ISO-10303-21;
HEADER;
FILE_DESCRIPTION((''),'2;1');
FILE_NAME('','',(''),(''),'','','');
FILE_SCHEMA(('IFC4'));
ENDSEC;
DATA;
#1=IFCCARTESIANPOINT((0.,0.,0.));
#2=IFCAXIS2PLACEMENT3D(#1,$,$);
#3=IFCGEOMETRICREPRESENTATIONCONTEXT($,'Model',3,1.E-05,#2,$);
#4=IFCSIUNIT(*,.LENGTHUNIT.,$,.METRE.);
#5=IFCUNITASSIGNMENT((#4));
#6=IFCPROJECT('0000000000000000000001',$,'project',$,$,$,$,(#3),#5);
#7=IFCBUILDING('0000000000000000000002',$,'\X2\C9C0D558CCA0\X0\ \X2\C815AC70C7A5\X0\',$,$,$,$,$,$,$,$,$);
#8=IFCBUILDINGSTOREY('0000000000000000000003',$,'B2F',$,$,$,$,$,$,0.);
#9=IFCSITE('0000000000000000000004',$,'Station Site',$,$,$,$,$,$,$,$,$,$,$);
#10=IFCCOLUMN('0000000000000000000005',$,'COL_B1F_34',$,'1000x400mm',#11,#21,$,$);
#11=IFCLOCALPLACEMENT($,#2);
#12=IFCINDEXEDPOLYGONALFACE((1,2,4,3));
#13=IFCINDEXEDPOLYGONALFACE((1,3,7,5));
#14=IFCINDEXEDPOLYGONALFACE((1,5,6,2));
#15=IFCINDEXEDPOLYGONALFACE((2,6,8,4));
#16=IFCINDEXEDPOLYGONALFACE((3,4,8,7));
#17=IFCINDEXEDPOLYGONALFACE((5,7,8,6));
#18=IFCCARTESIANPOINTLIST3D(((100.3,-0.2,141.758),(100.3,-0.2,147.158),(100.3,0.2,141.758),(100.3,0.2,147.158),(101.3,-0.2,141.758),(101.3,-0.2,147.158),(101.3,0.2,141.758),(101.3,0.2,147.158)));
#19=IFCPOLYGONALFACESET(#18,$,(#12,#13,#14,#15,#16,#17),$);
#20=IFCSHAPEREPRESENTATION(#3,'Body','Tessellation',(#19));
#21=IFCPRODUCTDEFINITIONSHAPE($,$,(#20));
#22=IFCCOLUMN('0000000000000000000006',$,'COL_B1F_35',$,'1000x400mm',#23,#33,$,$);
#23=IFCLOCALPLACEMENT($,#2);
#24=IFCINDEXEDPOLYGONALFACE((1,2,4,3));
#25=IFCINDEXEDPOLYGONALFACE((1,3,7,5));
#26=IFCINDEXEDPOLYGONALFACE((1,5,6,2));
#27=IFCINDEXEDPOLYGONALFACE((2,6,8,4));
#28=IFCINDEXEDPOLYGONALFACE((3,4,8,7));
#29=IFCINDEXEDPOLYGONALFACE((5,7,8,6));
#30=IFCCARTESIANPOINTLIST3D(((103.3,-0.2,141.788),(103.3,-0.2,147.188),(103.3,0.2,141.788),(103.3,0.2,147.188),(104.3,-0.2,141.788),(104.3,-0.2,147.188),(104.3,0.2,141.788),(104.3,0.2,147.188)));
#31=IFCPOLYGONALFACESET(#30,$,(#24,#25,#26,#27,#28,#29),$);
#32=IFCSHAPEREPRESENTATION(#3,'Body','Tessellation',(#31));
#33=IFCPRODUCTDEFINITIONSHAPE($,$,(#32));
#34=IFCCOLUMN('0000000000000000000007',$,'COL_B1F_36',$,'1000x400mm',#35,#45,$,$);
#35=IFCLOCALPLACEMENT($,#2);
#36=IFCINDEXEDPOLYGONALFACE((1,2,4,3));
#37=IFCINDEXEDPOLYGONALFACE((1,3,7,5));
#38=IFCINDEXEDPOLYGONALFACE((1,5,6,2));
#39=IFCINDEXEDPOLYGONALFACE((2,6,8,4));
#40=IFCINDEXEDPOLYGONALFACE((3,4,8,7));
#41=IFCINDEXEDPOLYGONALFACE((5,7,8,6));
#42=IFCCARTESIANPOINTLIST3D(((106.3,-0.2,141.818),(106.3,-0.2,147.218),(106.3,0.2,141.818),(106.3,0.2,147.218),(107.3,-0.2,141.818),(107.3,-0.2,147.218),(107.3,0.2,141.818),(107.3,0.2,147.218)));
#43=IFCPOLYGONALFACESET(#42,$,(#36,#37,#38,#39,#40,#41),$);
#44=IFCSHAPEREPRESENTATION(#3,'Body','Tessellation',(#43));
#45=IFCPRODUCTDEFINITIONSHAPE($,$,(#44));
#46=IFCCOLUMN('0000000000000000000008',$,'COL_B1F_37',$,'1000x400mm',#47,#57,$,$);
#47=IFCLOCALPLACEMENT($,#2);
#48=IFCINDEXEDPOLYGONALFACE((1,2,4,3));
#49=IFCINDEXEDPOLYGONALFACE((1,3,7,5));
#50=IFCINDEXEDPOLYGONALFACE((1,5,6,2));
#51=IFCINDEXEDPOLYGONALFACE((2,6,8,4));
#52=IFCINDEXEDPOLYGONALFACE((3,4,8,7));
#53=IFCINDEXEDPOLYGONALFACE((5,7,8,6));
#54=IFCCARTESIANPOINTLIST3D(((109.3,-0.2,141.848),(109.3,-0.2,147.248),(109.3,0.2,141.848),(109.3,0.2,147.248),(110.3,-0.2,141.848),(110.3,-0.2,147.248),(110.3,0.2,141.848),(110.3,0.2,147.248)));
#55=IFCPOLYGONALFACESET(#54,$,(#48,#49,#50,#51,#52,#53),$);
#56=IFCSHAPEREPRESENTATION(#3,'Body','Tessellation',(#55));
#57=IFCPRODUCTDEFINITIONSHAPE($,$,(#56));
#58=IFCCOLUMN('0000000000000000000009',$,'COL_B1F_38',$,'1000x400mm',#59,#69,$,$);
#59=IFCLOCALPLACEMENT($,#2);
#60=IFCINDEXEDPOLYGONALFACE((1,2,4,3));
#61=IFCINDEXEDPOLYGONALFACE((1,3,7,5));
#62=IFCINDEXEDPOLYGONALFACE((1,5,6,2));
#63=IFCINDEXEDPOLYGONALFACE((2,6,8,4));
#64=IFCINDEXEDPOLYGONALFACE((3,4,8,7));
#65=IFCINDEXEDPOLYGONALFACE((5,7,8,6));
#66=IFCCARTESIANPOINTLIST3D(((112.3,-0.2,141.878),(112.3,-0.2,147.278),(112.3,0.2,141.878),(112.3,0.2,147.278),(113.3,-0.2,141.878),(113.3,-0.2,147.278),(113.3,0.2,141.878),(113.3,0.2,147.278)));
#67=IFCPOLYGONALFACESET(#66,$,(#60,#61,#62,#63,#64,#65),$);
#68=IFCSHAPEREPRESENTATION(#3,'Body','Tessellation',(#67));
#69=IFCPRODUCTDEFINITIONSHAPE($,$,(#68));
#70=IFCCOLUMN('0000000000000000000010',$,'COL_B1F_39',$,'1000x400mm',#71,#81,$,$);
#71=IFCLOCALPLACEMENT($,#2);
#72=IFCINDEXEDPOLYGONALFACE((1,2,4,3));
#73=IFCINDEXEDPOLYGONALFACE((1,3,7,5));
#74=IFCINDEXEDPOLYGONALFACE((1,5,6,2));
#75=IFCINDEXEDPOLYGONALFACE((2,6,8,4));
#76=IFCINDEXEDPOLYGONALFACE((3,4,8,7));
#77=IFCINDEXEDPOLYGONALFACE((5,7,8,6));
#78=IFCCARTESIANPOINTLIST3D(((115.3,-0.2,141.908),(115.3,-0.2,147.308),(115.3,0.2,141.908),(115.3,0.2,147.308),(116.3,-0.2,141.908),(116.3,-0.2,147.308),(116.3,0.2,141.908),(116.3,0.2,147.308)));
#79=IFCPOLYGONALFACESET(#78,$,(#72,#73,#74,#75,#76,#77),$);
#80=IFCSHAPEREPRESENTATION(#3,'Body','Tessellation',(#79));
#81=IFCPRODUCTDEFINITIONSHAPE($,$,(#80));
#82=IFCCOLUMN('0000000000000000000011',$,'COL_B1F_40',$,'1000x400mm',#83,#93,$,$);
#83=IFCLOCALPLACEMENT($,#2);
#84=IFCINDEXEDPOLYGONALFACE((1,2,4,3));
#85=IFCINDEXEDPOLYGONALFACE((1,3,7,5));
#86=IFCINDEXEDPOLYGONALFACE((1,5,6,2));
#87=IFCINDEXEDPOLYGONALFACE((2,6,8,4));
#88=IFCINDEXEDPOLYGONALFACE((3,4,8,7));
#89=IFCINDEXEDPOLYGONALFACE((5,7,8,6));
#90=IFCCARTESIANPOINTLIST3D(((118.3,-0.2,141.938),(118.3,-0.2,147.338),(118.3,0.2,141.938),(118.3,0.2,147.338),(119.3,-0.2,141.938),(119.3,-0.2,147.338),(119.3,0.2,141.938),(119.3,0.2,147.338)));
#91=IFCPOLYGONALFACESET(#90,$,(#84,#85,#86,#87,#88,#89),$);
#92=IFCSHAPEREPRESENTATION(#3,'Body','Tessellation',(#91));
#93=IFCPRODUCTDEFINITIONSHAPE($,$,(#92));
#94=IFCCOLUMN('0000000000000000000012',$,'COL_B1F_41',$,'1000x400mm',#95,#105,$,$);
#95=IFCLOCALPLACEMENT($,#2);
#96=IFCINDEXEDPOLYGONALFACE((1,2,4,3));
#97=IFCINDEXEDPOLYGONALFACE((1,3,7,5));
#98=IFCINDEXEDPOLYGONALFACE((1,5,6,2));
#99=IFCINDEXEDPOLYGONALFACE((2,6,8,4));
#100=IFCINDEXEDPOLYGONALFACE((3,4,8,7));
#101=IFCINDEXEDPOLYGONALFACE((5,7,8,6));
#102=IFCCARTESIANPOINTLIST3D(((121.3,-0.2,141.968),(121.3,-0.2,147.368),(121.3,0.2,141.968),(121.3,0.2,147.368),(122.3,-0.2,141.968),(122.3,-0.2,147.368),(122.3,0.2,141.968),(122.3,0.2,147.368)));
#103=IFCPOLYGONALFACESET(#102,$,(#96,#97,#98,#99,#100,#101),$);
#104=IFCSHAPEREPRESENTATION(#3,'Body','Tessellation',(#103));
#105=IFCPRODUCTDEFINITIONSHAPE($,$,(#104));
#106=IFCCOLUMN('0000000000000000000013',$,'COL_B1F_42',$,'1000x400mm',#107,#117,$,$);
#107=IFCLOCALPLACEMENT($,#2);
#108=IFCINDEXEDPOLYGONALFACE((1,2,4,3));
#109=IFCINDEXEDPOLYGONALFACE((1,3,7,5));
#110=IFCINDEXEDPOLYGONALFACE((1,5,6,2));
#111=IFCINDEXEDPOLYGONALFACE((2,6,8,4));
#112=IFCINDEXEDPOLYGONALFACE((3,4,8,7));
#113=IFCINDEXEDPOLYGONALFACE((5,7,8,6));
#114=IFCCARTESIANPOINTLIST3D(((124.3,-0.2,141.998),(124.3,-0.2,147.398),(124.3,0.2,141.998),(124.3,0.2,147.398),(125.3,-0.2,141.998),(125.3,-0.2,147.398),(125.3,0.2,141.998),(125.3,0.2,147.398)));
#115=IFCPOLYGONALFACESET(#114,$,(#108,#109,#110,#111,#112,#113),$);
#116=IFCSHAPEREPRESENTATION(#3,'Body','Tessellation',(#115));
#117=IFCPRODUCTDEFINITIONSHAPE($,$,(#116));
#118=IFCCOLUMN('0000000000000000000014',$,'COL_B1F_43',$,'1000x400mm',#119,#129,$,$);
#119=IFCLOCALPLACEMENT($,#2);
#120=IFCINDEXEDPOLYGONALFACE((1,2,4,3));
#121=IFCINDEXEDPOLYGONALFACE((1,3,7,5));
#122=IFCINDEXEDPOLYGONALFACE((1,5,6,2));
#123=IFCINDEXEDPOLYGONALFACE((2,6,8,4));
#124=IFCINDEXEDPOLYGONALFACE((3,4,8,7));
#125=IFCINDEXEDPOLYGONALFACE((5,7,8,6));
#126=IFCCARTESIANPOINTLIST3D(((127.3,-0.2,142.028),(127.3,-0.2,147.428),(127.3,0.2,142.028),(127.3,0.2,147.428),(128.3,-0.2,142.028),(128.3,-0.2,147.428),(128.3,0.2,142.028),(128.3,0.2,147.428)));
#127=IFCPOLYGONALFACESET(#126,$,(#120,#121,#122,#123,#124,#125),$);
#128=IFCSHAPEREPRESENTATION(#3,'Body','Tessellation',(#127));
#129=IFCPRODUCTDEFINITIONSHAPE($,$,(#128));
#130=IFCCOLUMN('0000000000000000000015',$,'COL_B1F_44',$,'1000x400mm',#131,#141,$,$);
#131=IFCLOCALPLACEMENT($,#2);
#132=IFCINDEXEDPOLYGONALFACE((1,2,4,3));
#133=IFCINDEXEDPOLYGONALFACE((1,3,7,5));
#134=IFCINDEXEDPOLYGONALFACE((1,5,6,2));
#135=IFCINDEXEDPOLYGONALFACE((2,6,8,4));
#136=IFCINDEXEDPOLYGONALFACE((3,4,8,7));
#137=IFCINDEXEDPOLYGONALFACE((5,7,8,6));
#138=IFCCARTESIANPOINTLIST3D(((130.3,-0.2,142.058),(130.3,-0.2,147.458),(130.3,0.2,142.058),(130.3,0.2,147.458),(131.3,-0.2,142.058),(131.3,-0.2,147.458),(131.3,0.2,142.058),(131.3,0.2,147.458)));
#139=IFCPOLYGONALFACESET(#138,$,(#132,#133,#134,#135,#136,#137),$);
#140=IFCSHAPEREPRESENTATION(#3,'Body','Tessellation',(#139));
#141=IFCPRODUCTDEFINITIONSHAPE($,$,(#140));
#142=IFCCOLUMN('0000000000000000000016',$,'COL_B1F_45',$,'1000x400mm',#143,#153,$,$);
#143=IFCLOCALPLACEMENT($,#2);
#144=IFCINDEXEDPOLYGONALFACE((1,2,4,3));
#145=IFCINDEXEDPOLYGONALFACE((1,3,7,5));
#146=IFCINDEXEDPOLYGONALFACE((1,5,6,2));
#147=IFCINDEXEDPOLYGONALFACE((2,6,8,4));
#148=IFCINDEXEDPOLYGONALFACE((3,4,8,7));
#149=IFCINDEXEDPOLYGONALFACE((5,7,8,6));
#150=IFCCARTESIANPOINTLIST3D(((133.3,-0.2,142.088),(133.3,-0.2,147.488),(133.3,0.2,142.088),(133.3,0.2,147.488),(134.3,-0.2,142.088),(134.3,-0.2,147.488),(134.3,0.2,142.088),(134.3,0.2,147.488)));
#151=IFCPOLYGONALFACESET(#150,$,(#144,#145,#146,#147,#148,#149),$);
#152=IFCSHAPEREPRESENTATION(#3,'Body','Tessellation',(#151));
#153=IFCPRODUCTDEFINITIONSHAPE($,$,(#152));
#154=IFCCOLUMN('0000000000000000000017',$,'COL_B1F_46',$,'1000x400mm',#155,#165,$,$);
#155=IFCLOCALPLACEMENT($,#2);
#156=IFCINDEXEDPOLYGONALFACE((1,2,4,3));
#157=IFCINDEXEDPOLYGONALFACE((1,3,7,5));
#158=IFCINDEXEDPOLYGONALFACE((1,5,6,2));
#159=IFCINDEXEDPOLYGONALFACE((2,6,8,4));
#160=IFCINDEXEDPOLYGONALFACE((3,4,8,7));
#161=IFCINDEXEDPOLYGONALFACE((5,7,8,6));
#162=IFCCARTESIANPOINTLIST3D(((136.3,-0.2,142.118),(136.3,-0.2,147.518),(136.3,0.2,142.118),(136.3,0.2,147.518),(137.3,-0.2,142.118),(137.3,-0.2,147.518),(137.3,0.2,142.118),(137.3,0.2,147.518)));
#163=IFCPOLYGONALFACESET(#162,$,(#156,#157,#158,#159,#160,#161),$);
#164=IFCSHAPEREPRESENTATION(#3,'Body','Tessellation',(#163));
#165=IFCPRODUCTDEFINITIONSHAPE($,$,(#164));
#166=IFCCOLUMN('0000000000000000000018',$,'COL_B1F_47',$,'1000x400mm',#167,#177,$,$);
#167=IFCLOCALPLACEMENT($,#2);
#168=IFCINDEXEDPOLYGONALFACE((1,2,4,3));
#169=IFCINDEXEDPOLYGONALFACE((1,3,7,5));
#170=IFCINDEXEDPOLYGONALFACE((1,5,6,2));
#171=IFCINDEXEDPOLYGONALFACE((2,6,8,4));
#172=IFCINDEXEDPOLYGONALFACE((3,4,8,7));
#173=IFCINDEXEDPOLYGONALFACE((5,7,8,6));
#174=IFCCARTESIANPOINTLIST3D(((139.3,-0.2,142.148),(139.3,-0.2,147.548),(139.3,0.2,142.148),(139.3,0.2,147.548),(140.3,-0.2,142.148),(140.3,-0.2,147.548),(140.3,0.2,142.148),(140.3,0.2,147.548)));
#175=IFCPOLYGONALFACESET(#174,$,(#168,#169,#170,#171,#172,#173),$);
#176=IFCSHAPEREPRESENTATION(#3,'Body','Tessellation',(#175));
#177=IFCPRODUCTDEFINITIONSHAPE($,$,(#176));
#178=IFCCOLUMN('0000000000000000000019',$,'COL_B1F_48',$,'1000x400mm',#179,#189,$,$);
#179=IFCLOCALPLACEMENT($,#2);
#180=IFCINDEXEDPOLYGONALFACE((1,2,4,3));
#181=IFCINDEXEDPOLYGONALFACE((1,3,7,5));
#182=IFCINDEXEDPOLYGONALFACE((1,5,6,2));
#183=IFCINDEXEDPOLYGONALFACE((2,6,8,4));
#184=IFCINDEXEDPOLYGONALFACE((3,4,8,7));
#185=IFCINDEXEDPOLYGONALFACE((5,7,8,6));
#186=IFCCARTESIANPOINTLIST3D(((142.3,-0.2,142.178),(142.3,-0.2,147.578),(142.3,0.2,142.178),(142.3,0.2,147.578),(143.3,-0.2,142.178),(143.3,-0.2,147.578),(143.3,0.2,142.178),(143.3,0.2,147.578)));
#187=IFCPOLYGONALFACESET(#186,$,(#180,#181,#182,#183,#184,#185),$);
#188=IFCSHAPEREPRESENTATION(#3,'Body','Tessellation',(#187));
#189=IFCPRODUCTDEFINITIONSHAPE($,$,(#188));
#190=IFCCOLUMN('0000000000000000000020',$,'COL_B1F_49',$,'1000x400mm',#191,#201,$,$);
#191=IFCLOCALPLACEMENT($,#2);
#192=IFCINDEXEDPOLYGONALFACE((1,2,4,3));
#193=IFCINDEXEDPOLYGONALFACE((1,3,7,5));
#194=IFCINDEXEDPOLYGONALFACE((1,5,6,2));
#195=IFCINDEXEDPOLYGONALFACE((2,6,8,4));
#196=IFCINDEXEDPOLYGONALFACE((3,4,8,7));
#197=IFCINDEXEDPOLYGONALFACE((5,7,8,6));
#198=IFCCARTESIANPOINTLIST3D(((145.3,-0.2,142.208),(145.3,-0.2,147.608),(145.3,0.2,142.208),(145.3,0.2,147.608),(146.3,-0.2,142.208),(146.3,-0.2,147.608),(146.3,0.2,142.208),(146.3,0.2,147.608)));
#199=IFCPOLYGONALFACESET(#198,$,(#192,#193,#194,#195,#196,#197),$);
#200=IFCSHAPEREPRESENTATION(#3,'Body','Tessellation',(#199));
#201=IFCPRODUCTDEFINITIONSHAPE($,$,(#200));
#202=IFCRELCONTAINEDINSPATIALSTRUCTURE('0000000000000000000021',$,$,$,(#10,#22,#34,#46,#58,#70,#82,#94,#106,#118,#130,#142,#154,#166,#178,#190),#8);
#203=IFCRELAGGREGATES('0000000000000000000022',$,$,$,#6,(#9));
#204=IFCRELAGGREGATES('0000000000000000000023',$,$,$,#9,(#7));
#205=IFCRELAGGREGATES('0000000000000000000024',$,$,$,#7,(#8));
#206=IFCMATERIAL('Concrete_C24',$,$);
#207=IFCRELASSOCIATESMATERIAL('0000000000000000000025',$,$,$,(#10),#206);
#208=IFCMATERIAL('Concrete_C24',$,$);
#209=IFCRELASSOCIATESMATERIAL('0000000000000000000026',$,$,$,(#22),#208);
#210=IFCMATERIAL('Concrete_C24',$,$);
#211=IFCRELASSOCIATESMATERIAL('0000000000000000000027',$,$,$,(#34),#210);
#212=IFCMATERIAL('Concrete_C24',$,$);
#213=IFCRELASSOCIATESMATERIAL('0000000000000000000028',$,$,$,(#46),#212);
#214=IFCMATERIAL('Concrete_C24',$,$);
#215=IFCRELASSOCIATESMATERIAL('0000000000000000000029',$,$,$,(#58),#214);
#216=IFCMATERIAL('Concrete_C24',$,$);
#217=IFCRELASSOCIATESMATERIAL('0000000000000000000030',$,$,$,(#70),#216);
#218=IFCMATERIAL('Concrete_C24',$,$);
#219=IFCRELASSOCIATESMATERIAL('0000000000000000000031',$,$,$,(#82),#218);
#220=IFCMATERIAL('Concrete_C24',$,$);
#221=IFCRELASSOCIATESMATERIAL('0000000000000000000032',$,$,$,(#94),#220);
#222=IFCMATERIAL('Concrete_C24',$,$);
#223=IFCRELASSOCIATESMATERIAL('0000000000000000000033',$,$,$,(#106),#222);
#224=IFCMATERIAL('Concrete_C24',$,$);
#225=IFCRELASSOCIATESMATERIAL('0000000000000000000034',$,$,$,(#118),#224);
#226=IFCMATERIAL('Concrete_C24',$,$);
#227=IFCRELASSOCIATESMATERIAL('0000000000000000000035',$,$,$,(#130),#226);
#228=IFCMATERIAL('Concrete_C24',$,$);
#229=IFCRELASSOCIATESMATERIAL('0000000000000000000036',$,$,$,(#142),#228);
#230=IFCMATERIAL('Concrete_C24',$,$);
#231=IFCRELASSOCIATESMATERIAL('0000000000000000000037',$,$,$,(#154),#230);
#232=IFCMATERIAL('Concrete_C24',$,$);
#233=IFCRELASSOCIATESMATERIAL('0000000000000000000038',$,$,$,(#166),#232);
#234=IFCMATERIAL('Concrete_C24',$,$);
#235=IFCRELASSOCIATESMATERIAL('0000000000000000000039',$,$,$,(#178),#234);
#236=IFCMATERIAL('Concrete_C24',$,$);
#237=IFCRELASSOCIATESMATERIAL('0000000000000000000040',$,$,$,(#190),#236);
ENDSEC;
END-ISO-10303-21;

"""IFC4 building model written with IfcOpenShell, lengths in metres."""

from ifc_helpers import new_model, si_unit, frame, origin, place, context, project, spatial, rectangle, extrude, material, element, save


model = new_model("IFC4")

# Units and contexts
model_context = context("Model", 3, precision=1e-05, world=origin())
ifc_project = project(units=[si_unit("LENGTHUNIT", "METRE")], contexts=[model_context])

# Site, building, storey
site = spatial("IfcSite", under=ifc_project, Name="Station Site")
building = spatial("IfcBuilding", under=site, Name="지하철 정거장")
storey = spatial("IfcBuildingStorey", under=building, Name="B2F", Elevation=0.0)

# Columns
ifc_material_1 = material(Name="Concrete_C24")
column_1_placement = place(None, frame((100.8, 0.0, 141.758)))
element("IfcColumn", 1, at=column_1_placement, inside=storey, material=ifc_material_1, Name="COL_B1F_34", ObjectType="1000x400mm", context=model_context, shape_type="SweptSolid", body=[
    extrude(rectangle(XDim=1.0, YDim=0.4), origin(), (0.0, 0.0, 1.0), 5.4),
])
ifc_material_2 = material(Name="Concrete_C24")
column_2_placement = place(None, frame((103.8, 0.0, 141.788)))
element("IfcColumn", 2, at=column_2_placement, inside=storey, material=ifc_material_2, Name="COL_B1F_35", ObjectType="1000x400mm", context=model_context, shape_type="SweptSolid", body=[
    extrude(rectangle(XDim=1.0, YDim=0.4), origin(), (0.0, 0.0, 1.0), 5.4),
])
ifc_material_3 = material(Name="Concrete_C24")
column_3_placement = place(None, frame((106.8, 0.0, 141.818)))
element("IfcColumn", 3, at=column_3_placement, inside=storey, material=ifc_material_3, Name="COL_B1F_36", ObjectType="1000x400mm", context=model_context, shape_type="SweptSolid", body=[
    extrude(rectangle(XDim=1.0, YDim=0.4), origin(), (0.0, 0.0, 1.0), 5.4),
])
ifc_material_4 = material(Name="Concrete_C24")
column_4_placement = place(None, frame((109.8, 0.0, 141.848)))
element("IfcColumn", 4, at=column_4_placement, inside=storey, material=ifc_material_4, Name="COL_B1F_37", ObjectType="1000x400mm", context=model_context, shape_type="SweptSolid", body=[
    extrude(rectangle(XDim=1.0, YDim=0.4), origin(), (0.0, 0.0, 1.0), 5.4),
])
ifc_material_5 = material(Name="Concrete_C24")
column_5_placement = place(None, frame((112.8, 0.0, 141.878)))
element("IfcColumn", 5, at=column_5_placement, inside=storey, material=ifc_material_5, Name="COL_B1F_38", ObjectType="1000x400mm", context=model_context, shape_type="SweptSolid", body=[
    extrude(rectangle(XDim=1.0, YDim=0.4), origin(), (0.0, 0.0, 1.0), 5.4),
])
ifc_material_6 = material(Name="Concrete_C24")
column_6_placement = place(None, frame((115.8, 0.0, 141.908)))
element("IfcColumn", 6, at=column_6_placement, inside=storey, material=ifc_material_6, Name="COL_B1F_39", ObjectType="1000x400mm", context=model_context, shape_type="SweptSolid", body=[
    extrude(rectangle(XDim=1.0, YDim=0.4), origin(), (0.0, 0.0, 1.0), 5.4),
])
ifc_material_7 = material(Name="Concrete_C24")
column_7_placement = place(None, frame((118.8, 0.0, 141.938)))
element("IfcColumn", 7, at=column_7_placement, inside=storey, material=ifc_material_7, Name="COL_B1F_40", ObjectType="1000x400mm", context=model_context, shape_type="SweptSolid", body=[
    extrude(rectangle(XDim=1.0, YDim=0.4), origin(), (0.0, 0.0, 1.0), 5.4),
])
ifc_material_8 = material(Name="Concrete_C24")
column_8_placement = place(None, frame((121.8, 0.0, 141.968)))
element("IfcColumn", 8, at=column_8_placement, inside=storey, material=ifc_material_8, Name="COL_B1F_41", ObjectType="1000x400mm", context=model_context, shape_type="SweptSolid", body=[
    extrude(rectangle(XDim=1.0, YDim=0.4), origin(), (0.0, 0.0, 1.0), 5.4),
])
ifc_material_9 = material(Name="Concrete_C24")
column_9_placement = place(None, frame((124.8, 0.0, 141.998)))
element("IfcColumn", 9, at=column_9_placement, inside=storey, material=ifc_material_9, Name="COL_B1F_42", ObjectType="1000x400mm", context=model_context, shape_type="SweptSolid", body=[
    extrude(rectangle(XDim=1.0, YDim=0.4), origin(), (0.0, 0.0, 1.0), 5.4),
])
ifc_material_10 = material(Name="Concrete_C24")
column_10_placement = place(None, frame((127.8, 0.0, 142.028)))
element("IfcColumn", 10, at=column_10_placement, inside=storey, material=ifc_material_10, Name="COL_B1F_43", ObjectType="1000x400mm", context=model_context, shape_type="SweptSolid", body=[
    extrude(rectangle(XDim=1.0, YDim=0.4), origin(), (0.0, 0.0, 1.0), 5.4),
])
ifc_material_11 = material(Name="Concrete_C24")
column_11_placement = place(None, frame((130.8, 0.0, 142.058)))
element("IfcColumn", 11, at=column_11_placement, inside=storey, material=ifc_material_11, Name="COL_B1F_44", ObjectType="1000x400mm", context=model_context, shape_type="SweptSolid", body=[
    extrude(rectangle(XDim=1.0, YDim=0.4), origin(), (0.0, 0.0, 1.0), 5.4),
])
ifc_material_12 = material(Name="Concrete_C24")
column_12_placement = place(None, frame((133.8, 0.0, 142.088)))
element("IfcColumn", 12, at=column_12_placement, inside=storey, material=ifc_material_12, Name="COL_B1F_45", ObjectType="1000x400mm", context=model_context, shape_type="SweptSolid", body=[
    extrude(rectangle(XDim=1.0, YDim=0.4), origin(), (0.0, 0.0, 1.0), 5.4),
])
ifc_material_13 = material(Name="Concrete_C24")
column_13_placement = place(None, frame((136.8, 0.0, 142.118)))
element("IfcColumn", 13, at=column_13_placement, inside=storey, material=ifc_material_13, Name="COL_B1F_46", ObjectType="1000x400mm", context=model_context, shape_type="SweptSolid", body=[
    extrude(rectangle(XDim=1.0, YDim=0.4), origin(), (0.0, 0.0, 1.0), 5.4),
])
ifc_material_14 = material(Name="Concrete_C24")
column_14_placement = place(None, frame((139.8, 0.0, 142.148)))
element("IfcColumn", 14, at=column_14_placement, inside=storey, material=ifc_material_14, Name="COL_B1F_47", ObjectType="1000x400mm", context=model_context, shape_type="SweptSolid", body=[
    extrude(rectangle(XDim=1.0, YDim=0.4), origin(), (0.0, 0.0, 1.0), 5.4),
])
ifc_material_15 = material(Name="Concrete_C24")
column_15_placement = place(None, frame((142.8, 0.0, 142.178)))
element("IfcColumn", 15, at=column_15_placement, inside=storey, material=ifc_material_15, Name="COL_B1F_48", ObjectType="1000x400mm", context=model_context, shape_type="SweptSolid", body=[
    extrude(rectangle(XDim=1.0, YDim=0.4), origin(), (0.0, 0.0, 1.0), 5.4),
])
ifc_material_16 = material(Name="Concrete_C24")
column_16_placement = place(None, frame((145.8, 0.0, 142.208)))
element("IfcColumn", 16, at=column_16_placement, inside=storey, material=ifc_material_16, Name="COL_B1F_49", ObjectType="1000x400mm", context=model_context, shape_type="SweptSolid", body=[
    extrude(rectangle(XDim=1.0, YDim=0.4), origin(), (0.0, 0.0, 1.0), 5.4),
])

save(model, "model.ifc")
